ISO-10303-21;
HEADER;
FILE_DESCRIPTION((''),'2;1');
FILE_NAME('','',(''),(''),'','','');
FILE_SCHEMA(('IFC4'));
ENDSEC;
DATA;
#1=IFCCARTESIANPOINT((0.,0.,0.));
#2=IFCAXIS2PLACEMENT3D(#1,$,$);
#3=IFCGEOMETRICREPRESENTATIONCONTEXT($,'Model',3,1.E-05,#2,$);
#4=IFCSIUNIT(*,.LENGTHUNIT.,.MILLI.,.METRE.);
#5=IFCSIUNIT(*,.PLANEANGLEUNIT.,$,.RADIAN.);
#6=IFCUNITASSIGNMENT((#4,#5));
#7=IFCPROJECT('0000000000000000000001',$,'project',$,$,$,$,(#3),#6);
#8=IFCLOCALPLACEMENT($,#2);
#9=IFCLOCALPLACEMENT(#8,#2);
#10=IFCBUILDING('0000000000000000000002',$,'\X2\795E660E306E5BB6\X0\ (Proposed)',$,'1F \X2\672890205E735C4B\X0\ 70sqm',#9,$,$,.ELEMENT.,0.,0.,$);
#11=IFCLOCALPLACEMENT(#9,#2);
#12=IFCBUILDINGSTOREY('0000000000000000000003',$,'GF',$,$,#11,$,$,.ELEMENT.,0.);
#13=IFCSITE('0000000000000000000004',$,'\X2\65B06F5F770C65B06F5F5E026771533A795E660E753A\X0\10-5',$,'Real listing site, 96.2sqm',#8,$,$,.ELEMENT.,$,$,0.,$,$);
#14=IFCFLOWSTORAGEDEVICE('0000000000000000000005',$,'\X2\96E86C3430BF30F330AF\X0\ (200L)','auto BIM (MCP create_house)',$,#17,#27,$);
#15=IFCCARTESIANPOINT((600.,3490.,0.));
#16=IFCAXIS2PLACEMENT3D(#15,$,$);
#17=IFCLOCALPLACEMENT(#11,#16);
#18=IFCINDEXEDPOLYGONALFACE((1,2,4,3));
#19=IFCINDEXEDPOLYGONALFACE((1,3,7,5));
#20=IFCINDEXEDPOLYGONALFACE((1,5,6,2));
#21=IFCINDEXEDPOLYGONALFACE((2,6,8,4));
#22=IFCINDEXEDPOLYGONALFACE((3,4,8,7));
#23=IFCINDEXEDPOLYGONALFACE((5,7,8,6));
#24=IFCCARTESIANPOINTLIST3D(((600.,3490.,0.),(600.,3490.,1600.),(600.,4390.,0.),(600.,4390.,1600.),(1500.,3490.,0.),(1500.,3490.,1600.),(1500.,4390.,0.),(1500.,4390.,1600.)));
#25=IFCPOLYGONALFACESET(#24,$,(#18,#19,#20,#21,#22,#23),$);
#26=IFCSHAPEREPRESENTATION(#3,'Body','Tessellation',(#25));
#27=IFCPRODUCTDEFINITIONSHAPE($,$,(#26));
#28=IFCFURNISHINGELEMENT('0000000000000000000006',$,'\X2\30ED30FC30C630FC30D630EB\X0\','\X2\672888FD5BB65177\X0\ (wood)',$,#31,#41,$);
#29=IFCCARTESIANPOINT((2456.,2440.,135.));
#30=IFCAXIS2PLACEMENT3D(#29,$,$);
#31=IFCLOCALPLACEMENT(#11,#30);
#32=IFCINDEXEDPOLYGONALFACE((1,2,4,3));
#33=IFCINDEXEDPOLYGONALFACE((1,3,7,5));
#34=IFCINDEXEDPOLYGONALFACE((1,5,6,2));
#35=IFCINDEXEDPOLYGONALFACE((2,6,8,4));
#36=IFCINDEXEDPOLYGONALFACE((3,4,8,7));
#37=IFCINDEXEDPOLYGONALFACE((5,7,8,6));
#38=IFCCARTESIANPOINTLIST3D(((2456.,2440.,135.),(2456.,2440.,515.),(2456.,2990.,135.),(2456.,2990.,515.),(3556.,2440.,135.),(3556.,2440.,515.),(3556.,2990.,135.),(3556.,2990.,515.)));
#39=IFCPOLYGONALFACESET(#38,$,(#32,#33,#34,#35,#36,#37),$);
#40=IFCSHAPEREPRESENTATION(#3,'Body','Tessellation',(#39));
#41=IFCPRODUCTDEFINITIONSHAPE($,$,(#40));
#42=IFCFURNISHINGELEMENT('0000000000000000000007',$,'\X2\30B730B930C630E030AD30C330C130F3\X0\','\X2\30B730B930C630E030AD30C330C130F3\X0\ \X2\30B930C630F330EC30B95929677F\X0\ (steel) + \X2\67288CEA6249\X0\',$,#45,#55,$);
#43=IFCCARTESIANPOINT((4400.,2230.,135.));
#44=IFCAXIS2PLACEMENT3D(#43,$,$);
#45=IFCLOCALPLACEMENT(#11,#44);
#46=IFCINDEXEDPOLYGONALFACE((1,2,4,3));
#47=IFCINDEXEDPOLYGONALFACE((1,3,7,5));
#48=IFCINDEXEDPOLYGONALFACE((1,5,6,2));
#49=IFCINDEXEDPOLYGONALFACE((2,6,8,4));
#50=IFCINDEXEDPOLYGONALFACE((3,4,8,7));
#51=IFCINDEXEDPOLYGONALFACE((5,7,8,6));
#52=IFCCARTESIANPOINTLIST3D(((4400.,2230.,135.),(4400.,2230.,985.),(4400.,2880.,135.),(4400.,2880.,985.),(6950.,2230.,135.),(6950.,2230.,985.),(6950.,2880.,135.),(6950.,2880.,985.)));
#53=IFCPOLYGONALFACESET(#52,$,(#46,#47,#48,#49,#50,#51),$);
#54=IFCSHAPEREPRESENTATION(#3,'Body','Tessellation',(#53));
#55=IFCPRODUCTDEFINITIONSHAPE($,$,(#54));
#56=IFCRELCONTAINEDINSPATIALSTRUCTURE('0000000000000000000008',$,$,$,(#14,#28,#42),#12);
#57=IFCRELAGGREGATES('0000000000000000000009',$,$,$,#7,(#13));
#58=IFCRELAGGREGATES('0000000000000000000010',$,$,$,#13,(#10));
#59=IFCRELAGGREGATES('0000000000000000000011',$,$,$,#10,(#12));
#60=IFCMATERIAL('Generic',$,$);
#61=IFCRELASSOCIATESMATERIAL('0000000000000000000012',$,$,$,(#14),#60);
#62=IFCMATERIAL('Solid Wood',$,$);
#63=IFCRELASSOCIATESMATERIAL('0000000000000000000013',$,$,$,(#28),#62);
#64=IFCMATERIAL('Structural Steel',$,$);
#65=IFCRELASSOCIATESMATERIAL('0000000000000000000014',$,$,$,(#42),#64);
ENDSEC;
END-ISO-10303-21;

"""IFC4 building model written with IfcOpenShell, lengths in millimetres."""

from ifc_helpers import new_model, si_unit, frame, frame_2d, origin, place, context, project, spatial, rectangle, extrude, material, element, save


model = new_model("IFC4")

# Units and contexts
model_context = context("Model", 3, precision=1e-05, world=origin())
ifc_project = project(units=[si_unit("LENGTHUNIT", "METRE", prefix="MILLI"), si_unit("PLANEANGLEUNIT", "RADIAN")], contexts=[model_context])

# Site, building, storey
site_placement = place(None, origin())
site = spatial("IfcSite", under=ifc_project, at=site_placement, Name="新潟県新潟市東区神明町10-5", ObjectType="Real listing site, 96.2sqm", CompositionType="ELEMENT", RefElevation=0.0)
building_placement = place(site_placement, origin())
building = spatial("IfcBuilding", under=site, at=building_placement, Name="神明の家 (Proposed)", ObjectType="1F 木造平屋 70sqm", CompositionType="ELEMENT", ElevationOfRefHeight=0.0, ElevationOfTerrain=0.0)
storey_placement = place(building_placement, origin())
storey = spatial("IfcBuildingStorey", under=building, at=storey_placement, Name="GF", CompositionType="ELEMENT", Elevation=0.0)

# Shared definitions
ifc_material_1 = material(Name="Solid Wood")

# Shared definitions
ifc_material_2 = material(Name="Generic")

# Flow storage device
flow_storage_device_placement = place(storey_placement, frame((600.0, 3490.0, 0.0)))
element("IfcFlowStorageDevice", 1, at=flow_storage_device_placement, inside=storey, material=ifc_material_2, Name="雨水タンク (200L)", Description="auto BIM (MCP create_house)", context=model_context, shape_type="SweptSolid", body=[
    extrude(rectangle(XDim=900.0, YDim=900.0, at=frame_2d((450.0, 450.0))), frame((600.0, 3490.0, 0.0)), (0.0, 0.0, 1.0), 1600.0),
])

# Furnishing elements
furnishing_1_placement = place(storey_placement, frame((2456.0, 2440.0, 135.0)))
element("IfcFurnishingElement", 2, at=furnishing_1_placement, inside=storey, material=ifc_material_1, Name="ローテーブル", Description="木製家具 (wood)", context=model_context, shape_type="SweptSolid", body=[
    extrude(rectangle(XDim=1100.0, YDim=550.0, at=frame_2d((550.0, 275.0))), frame((2456.0, 2440.0, 135.0)), (0.0, 0.0, 1.0), 380.0),
])
ifc_material_3 = material(Name="Structural Steel")
furnishing_2_placement = place(storey_placement, frame((4400.0, 2230.0, 135.0)))
element("IfcFurnishingElement", 3, at=furnishing_2_placement, inside=storey, material=ifc_material_3, Name="システムキッチン", Description="システムキッチン ステンレス天板 (steel) + 木質扉", context=model_context, shape_type="SweptSolid", body=[
    extrude(rectangle(XDim=2550.0, YDim=650.0, at=frame_2d((1275.0, 325.0))), frame((4400.0, 2230.0, 135.0)), (0.0, 0.0, 1.0), 850.0),
])

save(model, "model.ifc")
